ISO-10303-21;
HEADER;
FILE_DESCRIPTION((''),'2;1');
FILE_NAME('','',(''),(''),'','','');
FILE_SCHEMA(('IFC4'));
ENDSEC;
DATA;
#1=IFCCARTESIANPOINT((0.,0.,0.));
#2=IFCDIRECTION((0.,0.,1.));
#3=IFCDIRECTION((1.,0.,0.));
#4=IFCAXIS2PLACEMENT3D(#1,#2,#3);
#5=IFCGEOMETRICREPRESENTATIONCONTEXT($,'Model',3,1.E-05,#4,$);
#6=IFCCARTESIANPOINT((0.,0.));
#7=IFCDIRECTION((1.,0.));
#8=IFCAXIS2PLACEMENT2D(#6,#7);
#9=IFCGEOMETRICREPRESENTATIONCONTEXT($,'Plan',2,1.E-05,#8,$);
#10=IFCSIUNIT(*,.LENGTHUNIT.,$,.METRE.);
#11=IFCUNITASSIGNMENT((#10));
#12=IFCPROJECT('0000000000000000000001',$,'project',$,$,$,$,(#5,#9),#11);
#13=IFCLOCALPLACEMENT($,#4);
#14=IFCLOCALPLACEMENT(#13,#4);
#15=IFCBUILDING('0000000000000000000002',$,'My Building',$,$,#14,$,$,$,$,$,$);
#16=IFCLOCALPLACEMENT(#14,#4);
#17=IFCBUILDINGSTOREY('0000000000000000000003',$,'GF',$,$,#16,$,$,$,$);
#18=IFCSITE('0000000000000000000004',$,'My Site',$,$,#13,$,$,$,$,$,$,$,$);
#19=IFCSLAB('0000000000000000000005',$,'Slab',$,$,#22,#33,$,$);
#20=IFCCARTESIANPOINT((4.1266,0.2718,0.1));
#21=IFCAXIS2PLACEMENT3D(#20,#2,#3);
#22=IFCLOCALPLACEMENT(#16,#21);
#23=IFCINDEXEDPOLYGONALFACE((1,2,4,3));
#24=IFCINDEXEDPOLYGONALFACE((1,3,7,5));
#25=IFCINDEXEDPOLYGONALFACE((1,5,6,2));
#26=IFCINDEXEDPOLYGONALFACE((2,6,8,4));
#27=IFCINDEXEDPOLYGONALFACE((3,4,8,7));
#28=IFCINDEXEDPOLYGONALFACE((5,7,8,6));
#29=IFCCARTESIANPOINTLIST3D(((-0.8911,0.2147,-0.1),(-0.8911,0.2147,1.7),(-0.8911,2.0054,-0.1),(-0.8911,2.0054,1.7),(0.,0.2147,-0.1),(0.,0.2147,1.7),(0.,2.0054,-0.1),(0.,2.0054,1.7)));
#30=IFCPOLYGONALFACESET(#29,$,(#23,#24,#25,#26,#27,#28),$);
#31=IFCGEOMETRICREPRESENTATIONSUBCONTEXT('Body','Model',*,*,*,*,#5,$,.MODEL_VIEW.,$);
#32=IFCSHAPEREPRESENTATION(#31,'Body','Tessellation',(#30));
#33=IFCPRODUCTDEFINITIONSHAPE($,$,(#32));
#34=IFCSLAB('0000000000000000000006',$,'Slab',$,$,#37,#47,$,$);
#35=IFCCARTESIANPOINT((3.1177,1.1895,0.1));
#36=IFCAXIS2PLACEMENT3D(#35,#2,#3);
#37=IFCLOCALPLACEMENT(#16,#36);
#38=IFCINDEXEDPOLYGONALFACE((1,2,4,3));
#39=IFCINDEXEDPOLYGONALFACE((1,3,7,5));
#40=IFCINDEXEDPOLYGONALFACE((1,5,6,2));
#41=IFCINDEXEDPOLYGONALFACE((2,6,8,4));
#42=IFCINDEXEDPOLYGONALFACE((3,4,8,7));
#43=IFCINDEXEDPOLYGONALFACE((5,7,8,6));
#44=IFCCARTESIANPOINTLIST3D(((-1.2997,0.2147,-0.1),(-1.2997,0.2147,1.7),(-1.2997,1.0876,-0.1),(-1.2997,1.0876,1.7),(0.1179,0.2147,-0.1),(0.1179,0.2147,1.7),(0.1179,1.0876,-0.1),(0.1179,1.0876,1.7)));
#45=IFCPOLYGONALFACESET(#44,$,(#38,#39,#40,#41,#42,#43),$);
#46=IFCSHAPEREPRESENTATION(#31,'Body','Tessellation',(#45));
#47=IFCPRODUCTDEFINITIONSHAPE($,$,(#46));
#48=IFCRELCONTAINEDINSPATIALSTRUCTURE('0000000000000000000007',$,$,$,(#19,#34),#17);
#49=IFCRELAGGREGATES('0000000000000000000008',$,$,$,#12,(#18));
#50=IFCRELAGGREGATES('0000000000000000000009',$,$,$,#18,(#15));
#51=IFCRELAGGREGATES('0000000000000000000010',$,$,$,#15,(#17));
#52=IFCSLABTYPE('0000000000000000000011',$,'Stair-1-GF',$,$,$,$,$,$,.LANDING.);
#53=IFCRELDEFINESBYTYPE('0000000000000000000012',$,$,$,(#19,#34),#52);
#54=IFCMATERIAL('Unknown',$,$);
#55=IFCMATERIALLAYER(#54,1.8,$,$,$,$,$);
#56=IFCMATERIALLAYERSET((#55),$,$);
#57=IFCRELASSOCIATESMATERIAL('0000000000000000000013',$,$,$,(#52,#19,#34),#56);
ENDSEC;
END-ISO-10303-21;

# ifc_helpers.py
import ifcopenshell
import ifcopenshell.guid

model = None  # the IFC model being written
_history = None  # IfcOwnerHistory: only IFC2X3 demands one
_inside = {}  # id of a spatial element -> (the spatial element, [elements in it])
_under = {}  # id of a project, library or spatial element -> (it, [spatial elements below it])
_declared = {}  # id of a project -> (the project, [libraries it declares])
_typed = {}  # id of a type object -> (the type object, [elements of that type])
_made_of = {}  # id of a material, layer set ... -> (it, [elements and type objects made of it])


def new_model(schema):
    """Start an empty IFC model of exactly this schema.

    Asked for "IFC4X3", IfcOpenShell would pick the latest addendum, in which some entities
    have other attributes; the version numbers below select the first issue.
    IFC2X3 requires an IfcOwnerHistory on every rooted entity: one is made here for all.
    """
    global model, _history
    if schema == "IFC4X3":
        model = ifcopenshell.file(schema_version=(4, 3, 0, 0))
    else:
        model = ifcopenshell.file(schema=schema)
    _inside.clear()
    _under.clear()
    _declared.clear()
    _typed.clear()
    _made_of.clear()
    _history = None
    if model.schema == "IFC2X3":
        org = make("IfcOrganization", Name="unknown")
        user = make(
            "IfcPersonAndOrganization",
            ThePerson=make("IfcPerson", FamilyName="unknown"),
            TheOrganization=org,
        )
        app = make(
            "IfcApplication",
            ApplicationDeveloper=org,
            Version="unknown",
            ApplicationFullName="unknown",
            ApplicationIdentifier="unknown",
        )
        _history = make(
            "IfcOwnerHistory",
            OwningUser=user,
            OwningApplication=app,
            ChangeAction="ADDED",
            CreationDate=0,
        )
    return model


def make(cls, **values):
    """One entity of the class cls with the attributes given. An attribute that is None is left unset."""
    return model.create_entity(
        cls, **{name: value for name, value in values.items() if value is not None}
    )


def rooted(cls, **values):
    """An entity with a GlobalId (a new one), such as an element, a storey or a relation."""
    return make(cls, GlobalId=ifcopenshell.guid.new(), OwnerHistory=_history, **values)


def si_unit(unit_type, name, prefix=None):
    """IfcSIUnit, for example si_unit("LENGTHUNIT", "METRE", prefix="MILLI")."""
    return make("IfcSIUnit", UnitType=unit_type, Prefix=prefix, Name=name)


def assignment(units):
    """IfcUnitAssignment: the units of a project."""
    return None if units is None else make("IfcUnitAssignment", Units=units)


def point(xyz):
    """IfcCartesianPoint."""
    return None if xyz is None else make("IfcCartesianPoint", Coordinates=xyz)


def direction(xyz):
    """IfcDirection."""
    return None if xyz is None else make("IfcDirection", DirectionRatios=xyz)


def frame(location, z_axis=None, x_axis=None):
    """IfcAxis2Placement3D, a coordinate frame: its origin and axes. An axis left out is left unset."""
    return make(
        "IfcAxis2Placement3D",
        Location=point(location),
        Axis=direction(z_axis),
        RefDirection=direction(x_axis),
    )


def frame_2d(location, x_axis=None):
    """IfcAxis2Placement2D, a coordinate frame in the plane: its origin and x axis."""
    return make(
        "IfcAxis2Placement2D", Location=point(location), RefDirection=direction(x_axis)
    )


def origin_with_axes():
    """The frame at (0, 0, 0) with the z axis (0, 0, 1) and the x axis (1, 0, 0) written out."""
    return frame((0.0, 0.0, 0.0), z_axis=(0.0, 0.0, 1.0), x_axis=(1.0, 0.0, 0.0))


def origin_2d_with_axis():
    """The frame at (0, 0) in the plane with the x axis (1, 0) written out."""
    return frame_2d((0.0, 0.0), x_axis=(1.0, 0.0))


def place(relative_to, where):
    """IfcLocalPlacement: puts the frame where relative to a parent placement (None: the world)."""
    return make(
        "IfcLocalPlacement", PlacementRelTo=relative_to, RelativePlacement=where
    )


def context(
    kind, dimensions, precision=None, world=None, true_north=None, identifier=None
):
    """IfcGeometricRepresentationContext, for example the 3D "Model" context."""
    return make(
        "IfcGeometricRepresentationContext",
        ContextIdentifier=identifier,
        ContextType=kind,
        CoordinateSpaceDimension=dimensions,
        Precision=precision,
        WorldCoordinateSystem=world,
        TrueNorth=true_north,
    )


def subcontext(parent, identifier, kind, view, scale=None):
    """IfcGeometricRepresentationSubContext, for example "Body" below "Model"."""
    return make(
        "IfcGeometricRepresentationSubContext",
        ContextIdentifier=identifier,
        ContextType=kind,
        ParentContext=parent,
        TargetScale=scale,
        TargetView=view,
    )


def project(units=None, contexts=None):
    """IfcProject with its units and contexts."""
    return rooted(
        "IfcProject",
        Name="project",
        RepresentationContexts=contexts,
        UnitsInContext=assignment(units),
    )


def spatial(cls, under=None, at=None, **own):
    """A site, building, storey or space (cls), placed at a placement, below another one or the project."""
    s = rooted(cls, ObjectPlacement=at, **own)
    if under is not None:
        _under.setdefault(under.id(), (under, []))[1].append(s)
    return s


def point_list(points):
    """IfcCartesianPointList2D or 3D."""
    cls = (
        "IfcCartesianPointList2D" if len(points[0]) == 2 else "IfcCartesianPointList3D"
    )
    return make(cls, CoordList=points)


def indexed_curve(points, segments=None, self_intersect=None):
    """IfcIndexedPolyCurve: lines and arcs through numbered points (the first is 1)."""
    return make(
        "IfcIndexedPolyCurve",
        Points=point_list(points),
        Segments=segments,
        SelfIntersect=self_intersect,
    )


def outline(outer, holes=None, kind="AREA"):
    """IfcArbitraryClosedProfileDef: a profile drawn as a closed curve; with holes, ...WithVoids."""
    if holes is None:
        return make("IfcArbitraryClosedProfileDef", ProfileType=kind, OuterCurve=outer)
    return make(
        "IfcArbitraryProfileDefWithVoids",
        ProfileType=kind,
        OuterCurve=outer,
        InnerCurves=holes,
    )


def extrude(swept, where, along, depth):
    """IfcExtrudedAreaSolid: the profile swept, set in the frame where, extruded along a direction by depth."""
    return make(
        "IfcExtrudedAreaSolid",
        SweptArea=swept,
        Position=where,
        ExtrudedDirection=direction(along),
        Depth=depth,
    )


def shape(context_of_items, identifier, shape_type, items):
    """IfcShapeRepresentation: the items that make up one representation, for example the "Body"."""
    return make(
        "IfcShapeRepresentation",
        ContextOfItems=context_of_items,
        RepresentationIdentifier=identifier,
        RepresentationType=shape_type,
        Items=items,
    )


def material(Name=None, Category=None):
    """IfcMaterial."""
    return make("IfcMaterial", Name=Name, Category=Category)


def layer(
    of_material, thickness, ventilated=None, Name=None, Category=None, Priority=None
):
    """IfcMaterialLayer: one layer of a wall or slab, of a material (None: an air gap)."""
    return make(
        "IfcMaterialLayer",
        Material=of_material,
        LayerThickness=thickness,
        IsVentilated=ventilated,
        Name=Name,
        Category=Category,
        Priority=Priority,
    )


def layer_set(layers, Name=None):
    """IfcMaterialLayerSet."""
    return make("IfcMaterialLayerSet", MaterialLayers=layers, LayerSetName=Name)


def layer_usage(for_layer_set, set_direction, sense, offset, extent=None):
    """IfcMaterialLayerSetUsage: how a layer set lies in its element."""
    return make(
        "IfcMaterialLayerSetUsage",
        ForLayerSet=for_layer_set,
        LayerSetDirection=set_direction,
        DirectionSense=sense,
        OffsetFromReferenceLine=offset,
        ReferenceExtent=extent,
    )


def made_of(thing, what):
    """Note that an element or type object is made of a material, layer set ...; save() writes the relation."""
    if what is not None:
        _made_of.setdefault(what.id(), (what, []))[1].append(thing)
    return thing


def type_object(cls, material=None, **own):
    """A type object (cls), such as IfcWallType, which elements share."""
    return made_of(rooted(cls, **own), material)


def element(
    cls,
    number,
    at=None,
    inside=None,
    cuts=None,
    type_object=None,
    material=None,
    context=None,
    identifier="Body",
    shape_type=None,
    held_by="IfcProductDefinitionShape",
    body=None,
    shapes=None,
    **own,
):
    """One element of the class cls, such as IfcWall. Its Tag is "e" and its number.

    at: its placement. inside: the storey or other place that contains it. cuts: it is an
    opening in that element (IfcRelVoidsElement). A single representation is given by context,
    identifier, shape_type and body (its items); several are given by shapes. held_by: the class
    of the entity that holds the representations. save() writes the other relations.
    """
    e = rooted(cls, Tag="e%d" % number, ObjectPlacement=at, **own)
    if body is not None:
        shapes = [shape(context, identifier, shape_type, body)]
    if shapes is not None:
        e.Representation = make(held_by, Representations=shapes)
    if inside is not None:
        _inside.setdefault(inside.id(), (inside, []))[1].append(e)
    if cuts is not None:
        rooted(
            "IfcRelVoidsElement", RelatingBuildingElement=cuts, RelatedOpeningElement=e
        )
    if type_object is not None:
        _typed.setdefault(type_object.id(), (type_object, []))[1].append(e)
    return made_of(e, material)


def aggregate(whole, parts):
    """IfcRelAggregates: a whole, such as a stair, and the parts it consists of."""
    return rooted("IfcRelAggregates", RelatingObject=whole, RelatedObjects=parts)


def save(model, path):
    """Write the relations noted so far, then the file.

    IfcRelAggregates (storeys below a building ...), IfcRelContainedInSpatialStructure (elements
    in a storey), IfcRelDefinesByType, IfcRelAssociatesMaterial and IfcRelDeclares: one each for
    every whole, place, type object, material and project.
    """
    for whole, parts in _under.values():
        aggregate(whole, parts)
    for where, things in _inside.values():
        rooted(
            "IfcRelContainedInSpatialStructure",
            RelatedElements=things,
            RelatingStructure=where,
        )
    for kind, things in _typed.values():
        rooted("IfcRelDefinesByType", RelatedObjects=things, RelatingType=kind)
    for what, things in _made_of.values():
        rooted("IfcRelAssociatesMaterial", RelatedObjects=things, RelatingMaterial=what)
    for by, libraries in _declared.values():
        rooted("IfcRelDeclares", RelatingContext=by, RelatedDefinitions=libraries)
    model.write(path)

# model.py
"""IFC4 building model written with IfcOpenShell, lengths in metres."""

from ifc_helpers import new_model, si_unit, frame, origin_with_axes, origin_2d_with_axis, place, context, subcontext, project, spatial, indexed_curve, outline, extrude, material, layer, layer_set, layer_usage, type_object, element, save


model = new_model("IFC4")

# Units and contexts
model_context = context("Model", 3, precision=1e-05, world=origin_with_axes())
plan_context = context("Plan", 2, precision=1e-05, world=origin_2d_with_axis())
body_context_1 = subcontext(model_context, "Body", "Model", "MODEL_VIEW")
ifc_project = project(units=[si_unit("LENGTHUNIT", "METRE")], contexts=[model_context, plan_context])

# Site, building, storey
site_placement = place(None, origin_with_axes())
site = spatial("IfcSite", under=ifc_project, at=site_placement, Name="My Site")
building_placement = place(site_placement, origin_with_axes())
building = spatial("IfcBuilding", under=site, at=building_placement, Name="My Building")
storey_placement = place(building_placement, origin_with_axes())
storey = spatial("IfcBuildingStorey", under=building, at=storey_placement, Name="GF")

# Slabs
ifc_material_1 = material(Name="Unknown")
ifc_layer_1 = layer(ifc_material_1, 1.8)
ifc_layer_set_1 = layer_set([ifc_layer_1])
ifc_layer_usage_1 = layer_usage(ifc_layer_set_1, "AXIS3", "POSITIVE", -0.1)
slab_type_1 = type_object("IfcSlabType", Name="Stair-1-GF", PredefinedType="LANDING", material=ifc_layer_set_1)
slab_1_placement = place(storey_placement, frame((4.1266, 0.2718, 0.1), z_axis=(0.0, 0.0, 1.0), x_axis=(1.0, 0.0, 0.0)))
element("IfcSlab", 1, at=slab_1_placement, inside=storey, type_object=slab_type_1, material=ifc_layer_usage_1, Name="Slab", context=body_context_1, shape_type="SweptSolid", body=[
    extrude(outline(indexed_curve([(-0.8911, 0.2147), (-0.8911, 2.0054), (0.0, 2.0054), (0.0, 0.2147), (-0.8911, 0.2147)])), frame((0.0, 0.0, -0.1), z_axis=(0.0, 0.0, 1.0), x_axis=(1.0, 0.0, 0.0)), (0.0, 0.0, 1.0), 1.8),
])
ifc_layer_usage_2 = layer_usage(ifc_layer_set_1, "AXIS3", "POSITIVE", -0.1)
slab_2_placement = place(storey_placement, frame((3.1177, 1.1895, 0.1), z_axis=(0.0, 0.0, 1.0), x_axis=(1.0, 0.0, 0.0)))
element("IfcSlab", 2, at=slab_2_placement, inside=storey, type_object=slab_type_1, material=ifc_layer_usage_2, Name="Slab", context=body_context_1, shape_type="SweptSolid", body=[
    extrude(outline(indexed_curve([(0.1179, 0.2147), (0.1179, 1.0876), (-1.2997, 1.0876), (-1.2997, 0.2147), (0.1179, 0.2147)])), frame((0.0, 0.0, -0.1), z_axis=(0.0, 0.0, 1.0), x_axis=(1.0, 0.0, 0.0)), (0.0, 0.0, 1.0), 1.8),
])

save(model, "model.ifc")
